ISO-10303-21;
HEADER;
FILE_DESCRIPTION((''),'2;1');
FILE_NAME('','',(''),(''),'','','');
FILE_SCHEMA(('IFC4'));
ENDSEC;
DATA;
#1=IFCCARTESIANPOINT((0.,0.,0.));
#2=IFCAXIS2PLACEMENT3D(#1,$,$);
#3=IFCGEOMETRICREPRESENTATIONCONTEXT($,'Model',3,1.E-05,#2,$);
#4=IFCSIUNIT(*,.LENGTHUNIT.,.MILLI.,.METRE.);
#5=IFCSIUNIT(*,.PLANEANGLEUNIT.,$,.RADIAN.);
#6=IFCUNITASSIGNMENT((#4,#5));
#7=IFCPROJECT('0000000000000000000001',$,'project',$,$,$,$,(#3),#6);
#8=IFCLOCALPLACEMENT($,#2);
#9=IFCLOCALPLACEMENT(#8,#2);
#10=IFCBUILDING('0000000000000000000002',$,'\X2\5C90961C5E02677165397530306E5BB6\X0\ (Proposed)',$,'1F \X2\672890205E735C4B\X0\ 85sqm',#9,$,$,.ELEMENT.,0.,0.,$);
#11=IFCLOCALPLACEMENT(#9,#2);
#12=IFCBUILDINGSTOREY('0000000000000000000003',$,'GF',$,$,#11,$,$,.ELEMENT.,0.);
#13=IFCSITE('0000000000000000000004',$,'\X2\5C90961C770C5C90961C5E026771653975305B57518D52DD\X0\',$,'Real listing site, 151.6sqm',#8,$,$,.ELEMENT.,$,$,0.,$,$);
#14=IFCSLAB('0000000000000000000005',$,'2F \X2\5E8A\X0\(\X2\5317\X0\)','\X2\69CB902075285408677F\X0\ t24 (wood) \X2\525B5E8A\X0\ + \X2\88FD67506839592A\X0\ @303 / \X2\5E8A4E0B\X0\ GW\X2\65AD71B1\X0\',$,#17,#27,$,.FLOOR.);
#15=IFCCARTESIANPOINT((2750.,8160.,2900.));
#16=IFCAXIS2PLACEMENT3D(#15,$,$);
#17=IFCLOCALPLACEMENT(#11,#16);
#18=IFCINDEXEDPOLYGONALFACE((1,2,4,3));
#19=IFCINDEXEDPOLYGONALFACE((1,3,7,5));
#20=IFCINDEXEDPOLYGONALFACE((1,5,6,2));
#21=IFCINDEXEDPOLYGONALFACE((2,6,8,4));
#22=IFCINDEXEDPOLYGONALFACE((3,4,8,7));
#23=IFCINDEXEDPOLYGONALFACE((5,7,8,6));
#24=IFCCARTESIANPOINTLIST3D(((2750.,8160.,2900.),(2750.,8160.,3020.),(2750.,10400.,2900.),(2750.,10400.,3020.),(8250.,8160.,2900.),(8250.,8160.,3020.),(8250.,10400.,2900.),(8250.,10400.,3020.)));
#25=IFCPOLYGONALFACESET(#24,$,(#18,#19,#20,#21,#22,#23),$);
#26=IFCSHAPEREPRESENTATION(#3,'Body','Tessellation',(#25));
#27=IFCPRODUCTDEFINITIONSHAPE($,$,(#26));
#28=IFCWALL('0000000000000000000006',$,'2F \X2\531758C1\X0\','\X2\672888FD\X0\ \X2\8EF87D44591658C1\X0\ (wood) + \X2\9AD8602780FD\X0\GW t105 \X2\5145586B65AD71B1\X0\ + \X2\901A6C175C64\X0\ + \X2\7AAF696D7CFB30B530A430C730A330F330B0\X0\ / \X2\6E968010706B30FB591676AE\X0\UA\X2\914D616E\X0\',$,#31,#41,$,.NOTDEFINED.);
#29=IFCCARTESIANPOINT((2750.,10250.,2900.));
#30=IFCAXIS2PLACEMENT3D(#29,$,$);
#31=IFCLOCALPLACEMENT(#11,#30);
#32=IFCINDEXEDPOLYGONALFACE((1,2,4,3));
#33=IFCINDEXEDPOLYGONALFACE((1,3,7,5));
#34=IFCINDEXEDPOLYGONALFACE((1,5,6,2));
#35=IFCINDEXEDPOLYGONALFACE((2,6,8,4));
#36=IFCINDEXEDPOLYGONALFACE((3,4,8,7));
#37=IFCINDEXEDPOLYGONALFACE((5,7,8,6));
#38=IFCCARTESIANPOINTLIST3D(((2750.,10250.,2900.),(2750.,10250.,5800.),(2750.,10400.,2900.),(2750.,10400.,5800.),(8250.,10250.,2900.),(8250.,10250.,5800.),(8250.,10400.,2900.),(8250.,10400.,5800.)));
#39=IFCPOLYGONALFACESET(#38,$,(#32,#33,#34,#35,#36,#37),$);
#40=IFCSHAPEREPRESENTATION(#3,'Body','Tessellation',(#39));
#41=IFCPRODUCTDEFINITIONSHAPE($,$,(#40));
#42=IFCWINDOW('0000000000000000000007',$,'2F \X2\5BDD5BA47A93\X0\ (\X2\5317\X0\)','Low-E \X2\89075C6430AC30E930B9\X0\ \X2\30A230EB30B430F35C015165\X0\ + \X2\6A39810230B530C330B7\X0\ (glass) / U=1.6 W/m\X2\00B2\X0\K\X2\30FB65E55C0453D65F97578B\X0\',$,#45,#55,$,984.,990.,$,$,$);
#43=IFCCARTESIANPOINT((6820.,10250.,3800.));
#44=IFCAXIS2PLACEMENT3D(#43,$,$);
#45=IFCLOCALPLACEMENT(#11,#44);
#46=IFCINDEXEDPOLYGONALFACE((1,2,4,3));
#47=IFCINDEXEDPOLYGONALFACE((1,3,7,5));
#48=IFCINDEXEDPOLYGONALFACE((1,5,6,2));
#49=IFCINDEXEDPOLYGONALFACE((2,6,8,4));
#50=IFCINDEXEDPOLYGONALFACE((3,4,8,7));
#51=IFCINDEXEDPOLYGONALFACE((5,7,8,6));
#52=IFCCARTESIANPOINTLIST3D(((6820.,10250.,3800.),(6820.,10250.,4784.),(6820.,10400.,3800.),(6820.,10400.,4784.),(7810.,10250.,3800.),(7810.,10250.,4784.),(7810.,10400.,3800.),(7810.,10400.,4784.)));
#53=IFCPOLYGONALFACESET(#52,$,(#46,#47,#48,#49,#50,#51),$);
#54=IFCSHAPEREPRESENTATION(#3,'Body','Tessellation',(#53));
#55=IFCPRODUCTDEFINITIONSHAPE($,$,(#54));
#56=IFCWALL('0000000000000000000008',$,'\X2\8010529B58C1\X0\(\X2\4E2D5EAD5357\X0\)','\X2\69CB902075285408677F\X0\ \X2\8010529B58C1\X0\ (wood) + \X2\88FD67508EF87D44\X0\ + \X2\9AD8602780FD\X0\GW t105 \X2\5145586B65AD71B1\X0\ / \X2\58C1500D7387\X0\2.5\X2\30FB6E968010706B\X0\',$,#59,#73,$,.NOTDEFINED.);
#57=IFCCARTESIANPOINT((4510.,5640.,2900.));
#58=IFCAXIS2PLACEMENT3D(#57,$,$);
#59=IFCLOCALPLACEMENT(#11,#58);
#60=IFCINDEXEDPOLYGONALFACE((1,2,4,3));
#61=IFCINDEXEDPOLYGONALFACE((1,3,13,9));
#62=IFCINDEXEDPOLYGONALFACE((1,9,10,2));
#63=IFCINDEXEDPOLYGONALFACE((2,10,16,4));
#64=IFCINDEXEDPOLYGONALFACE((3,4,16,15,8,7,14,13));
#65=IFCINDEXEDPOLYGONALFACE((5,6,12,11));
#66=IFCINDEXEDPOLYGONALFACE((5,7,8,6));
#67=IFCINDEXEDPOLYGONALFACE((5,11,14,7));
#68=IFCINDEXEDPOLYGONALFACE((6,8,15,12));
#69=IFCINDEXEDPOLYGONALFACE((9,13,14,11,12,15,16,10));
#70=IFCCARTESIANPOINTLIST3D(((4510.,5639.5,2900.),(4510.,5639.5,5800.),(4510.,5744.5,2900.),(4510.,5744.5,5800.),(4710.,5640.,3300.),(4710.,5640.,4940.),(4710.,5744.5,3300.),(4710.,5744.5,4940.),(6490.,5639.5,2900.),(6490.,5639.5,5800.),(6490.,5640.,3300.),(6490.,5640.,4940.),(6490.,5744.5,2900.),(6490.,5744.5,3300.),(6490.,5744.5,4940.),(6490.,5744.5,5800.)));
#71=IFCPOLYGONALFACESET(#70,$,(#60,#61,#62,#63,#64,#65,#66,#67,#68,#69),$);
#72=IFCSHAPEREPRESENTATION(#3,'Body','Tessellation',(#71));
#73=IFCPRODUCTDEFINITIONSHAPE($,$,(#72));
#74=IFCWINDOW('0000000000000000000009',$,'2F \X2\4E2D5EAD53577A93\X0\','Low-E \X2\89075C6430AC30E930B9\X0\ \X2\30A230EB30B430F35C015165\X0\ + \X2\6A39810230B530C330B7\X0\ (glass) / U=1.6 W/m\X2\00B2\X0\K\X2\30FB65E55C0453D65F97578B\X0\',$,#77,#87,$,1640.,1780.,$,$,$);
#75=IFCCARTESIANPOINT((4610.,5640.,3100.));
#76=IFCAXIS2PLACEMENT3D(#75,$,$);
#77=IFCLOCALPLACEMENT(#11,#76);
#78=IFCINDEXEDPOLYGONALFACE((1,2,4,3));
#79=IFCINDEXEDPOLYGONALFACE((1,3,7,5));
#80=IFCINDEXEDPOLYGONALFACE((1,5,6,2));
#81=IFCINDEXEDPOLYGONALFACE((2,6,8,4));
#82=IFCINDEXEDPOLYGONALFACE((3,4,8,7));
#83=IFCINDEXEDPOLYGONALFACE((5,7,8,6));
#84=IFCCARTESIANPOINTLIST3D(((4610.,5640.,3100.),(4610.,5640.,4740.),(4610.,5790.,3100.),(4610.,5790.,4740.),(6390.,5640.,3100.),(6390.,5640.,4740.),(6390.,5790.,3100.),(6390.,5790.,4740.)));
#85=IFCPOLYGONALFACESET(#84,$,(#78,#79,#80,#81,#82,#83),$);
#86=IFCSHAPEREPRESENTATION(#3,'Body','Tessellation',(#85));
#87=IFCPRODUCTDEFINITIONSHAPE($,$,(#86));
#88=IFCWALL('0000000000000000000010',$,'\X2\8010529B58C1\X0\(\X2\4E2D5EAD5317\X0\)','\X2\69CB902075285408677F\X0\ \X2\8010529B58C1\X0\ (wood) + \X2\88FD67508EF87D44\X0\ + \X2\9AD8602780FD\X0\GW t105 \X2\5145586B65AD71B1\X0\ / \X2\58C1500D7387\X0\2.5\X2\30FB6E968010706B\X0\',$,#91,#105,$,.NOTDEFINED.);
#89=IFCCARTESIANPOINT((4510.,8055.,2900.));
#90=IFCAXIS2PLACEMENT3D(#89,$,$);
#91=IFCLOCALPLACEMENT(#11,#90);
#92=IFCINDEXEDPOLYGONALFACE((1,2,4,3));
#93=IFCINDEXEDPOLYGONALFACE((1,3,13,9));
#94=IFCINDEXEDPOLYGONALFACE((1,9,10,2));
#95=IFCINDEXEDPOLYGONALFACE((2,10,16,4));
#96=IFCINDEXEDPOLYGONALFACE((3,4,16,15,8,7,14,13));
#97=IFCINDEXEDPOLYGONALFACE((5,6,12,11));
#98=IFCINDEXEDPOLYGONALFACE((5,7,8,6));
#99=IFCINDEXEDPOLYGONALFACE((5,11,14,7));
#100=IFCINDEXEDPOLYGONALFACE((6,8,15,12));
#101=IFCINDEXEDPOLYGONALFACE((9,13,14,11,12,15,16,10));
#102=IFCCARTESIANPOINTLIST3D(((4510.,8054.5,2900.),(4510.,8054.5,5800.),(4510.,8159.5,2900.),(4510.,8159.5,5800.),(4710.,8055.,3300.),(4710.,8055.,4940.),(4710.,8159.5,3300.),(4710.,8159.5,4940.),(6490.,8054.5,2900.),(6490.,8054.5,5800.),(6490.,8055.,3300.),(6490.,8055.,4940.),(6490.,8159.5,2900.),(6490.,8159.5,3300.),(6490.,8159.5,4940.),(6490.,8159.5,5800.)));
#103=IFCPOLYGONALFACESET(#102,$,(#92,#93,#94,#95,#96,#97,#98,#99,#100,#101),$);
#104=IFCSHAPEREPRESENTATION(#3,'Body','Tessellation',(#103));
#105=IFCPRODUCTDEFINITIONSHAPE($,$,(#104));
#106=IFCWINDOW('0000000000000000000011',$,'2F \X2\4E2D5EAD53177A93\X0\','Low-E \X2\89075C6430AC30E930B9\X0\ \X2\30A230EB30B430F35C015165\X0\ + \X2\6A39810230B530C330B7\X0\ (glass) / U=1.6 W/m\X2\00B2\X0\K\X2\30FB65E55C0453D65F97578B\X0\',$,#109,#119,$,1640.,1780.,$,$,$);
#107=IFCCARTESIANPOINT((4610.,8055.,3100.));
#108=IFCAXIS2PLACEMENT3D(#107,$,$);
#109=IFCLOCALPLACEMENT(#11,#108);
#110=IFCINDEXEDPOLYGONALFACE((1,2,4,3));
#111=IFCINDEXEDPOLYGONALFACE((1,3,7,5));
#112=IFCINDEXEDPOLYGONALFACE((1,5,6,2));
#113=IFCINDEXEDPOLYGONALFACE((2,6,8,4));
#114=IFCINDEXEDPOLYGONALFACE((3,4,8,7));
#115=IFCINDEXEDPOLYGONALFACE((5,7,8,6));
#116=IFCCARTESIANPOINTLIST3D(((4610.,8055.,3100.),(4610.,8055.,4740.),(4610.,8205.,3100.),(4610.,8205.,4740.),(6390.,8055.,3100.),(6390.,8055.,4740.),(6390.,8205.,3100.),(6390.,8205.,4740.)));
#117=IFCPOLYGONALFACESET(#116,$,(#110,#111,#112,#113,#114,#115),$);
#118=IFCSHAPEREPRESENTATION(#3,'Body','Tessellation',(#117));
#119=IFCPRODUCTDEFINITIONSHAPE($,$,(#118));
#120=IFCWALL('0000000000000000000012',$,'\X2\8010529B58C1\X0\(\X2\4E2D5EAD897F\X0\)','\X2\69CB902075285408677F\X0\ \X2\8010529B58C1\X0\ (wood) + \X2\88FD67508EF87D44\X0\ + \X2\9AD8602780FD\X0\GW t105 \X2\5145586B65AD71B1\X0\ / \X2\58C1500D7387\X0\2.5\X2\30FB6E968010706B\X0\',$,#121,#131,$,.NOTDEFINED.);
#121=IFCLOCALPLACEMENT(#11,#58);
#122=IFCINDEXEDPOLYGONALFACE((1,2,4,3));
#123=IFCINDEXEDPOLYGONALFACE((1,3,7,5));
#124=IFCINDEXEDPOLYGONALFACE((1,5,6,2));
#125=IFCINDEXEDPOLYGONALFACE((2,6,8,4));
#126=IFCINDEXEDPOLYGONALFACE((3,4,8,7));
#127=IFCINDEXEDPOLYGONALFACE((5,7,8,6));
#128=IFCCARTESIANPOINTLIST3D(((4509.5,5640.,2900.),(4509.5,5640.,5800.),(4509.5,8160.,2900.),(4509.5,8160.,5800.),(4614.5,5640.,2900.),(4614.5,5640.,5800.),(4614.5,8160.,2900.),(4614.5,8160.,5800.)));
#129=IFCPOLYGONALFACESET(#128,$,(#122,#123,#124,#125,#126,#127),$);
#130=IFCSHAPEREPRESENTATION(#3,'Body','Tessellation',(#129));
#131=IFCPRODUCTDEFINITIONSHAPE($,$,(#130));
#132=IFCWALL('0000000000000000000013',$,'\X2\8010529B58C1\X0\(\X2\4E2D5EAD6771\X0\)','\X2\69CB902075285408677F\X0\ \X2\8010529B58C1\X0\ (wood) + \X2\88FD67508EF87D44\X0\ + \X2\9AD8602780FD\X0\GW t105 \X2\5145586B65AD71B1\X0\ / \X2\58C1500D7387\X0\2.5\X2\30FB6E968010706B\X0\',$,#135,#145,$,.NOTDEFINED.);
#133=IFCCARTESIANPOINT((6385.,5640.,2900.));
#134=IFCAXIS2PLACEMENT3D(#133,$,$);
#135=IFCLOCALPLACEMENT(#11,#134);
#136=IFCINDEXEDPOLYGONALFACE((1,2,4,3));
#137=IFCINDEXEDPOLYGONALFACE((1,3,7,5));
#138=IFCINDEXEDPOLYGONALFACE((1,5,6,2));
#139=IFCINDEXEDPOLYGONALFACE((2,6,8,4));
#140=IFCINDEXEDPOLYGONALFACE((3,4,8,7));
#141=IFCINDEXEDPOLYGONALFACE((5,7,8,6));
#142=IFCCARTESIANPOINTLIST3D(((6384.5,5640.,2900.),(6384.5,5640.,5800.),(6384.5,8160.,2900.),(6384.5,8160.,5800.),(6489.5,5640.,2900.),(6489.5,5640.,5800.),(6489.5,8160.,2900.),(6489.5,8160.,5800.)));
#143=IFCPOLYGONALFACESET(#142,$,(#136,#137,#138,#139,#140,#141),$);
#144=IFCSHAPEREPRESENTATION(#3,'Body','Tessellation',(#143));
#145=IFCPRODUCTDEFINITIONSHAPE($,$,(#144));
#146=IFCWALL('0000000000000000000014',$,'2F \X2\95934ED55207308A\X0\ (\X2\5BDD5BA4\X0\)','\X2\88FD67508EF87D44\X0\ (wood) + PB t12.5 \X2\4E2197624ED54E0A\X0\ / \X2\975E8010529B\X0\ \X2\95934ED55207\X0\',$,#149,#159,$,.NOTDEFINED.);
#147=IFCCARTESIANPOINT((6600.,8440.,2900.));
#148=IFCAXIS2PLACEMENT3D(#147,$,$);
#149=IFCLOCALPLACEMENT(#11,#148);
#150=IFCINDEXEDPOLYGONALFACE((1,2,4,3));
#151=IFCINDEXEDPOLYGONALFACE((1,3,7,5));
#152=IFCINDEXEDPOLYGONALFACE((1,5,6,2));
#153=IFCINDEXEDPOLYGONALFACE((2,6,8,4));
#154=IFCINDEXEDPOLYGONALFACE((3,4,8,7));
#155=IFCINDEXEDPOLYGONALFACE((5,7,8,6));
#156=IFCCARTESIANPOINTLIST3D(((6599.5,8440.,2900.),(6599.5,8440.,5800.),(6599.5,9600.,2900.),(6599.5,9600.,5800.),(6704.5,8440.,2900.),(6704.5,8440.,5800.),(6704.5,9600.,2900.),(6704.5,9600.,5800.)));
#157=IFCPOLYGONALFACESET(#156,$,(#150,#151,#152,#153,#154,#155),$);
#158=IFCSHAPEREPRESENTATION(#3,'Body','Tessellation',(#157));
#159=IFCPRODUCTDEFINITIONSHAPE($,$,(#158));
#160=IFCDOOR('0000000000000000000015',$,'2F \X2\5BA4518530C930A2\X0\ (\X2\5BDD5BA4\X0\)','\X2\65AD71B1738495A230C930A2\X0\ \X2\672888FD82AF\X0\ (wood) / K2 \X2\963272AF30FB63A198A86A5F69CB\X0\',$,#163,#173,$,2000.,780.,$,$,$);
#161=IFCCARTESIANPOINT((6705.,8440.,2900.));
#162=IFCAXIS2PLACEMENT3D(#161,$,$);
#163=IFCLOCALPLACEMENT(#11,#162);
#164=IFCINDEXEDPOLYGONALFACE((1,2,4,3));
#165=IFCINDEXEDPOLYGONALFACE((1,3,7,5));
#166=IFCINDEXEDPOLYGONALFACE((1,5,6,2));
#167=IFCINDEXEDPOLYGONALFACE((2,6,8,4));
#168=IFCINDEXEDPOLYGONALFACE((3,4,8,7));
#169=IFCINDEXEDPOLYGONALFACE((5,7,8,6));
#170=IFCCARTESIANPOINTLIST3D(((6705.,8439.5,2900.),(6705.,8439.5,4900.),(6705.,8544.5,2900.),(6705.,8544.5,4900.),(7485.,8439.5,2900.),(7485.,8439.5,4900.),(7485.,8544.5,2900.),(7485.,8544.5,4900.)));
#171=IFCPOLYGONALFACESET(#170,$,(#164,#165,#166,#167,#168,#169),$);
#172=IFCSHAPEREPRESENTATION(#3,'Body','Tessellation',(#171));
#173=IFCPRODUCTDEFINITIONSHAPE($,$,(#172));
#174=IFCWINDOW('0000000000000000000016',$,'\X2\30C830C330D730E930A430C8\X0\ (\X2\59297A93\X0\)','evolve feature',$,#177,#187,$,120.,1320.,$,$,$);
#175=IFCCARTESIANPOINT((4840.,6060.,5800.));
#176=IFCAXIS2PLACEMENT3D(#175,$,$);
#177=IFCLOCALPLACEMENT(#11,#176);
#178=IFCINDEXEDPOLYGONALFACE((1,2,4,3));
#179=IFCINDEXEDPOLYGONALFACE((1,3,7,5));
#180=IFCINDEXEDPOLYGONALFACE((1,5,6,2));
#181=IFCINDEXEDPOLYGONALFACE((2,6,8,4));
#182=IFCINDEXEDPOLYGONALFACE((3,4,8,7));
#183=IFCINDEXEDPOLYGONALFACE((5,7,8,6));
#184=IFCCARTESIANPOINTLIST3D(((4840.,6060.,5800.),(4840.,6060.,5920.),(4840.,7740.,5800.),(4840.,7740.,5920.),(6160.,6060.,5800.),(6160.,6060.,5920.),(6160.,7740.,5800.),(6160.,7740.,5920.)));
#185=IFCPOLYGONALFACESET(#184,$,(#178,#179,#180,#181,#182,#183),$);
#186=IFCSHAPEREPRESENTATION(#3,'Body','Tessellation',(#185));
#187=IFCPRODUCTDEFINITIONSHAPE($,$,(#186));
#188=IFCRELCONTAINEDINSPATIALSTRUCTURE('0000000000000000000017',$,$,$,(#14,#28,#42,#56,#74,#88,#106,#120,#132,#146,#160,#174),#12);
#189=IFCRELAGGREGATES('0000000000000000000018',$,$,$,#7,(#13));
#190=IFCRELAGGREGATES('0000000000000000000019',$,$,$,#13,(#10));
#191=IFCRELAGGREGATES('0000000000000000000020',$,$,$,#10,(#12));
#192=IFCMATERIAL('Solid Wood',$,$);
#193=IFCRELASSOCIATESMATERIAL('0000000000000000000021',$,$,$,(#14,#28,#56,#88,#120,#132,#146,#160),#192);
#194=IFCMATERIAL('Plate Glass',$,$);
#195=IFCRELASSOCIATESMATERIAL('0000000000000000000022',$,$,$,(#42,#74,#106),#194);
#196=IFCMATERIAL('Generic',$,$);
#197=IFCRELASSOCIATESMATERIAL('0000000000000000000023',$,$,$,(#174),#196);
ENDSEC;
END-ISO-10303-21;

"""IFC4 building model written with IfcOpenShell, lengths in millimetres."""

from ifc_helpers import new_model, si_unit, frame, frame_2d, origin, place, context, project, spatial, rectangle, extrude, material, element, fill, save


model = new_model("IFC4")

# Units and contexts
model_context = context("Model", 3, precision=1e-05, world=origin())
ifc_project = project(units=[si_unit("LENGTHUNIT", "METRE", prefix="MILLI"), si_unit("PLANEANGLEUNIT", "RADIAN")], contexts=[model_context])

# Site, building, storey
site_placement = place(None, origin())
site = spatial("IfcSite", under=ifc_project, at=site_placement, Name="岐阜県岐阜市東改田字再勝", ObjectType="Real listing site, 151.6sqm", CompositionType="ELEMENT", RefElevation=0.0)
building_placement = place(site_placement, origin())
building = spatial("IfcBuilding", under=site, at=building_placement, Name="岐阜市東改田の家 (Proposed)", ObjectType="1F 木造平屋 85sqm", CompositionType="ELEMENT", ElevationOfRefHeight=0.0, ElevationOfTerrain=0.0)
storey_placement = place(building_placement, origin())
storey = spatial("IfcBuildingStorey", under=building, at=storey_placement, Name="GF", CompositionType="ELEMENT", Elevation=0.0)

# Slab
ifc_material_1 = material(Name="Solid Wood")
slab_placement = place(storey_placement, frame((2750.0, 8160.0, 2900.0)))
element("IfcSlab", 1, at=slab_placement, inside=storey, material=ifc_material_1, Name="2F 床(北)", Description="構造用合板 t24 (wood) 剛床 + 製材根太 @303 / 床下 GW断熱", PredefinedType="FLOOR", context=model_context, shape_type="SweptSolid", body=[
    extrude(rectangle(XDim=5500.0, YDim=2240.0, at=frame_2d((2750.0, 1120.0))), frame((2750.0, 8160.0, 2900.0)), (0.0, 0.0, 1.0), 120.0),
])

# Walls, openings, windows
wall_1_placement = place(storey_placement, frame((2750.0, 10250.0, 2900.0)))
wall_1 = element("IfcWall", 2, at=wall_1_placement, inside=storey, material=ifc_material_1, Name="2F 北壁", Description="木製 軸組外壁 (wood) + 高性能GW t105 充填断熱 + 通気層 + 窯業系サイディング / 準耐火・外皮UA配慮", PredefinedType="NOTDEFINED", context=model_context, shape_type="SweptSolid", body=[
    extrude(rectangle(XDim=5500.0, YDim=150.0, at=frame_2d((2750.0, 75.0))), frame((2750.0, 10250.0, 2900.0)), (0.0, 0.0, 1.0), 2900.0),
])
opening_1_placement = place(storey_placement, frame((6820.0, 10250.0, 3800.0)))
opening_1 = element("IfcOpeningElement", 3, at=opening_1_placement, cuts=wall_1, PredefinedType="NOTDEFINED", context=model_context, shape_type="SweptSolid", body=[
    extrude(rectangle(XDim=990.0, YDim=150.0, at=frame_2d((495.0, 75.0))), frame((6820.0, 10250.0, 3800.0)), (0.0, 0.0, 1.0), 984.0),
])
ifc_material_2 = material(Name="Plate Glass")
window_1_placement = place(storey_placement, frame((6820.0, 10250.0, 3800.0)))
window_1 = element("IfcWindow", 4, at=window_1_placement, inside=storey, material=ifc_material_2, Name="2F 寝室窓 (北)", Description="Low-E 複層ガラス アルゴン封入 + 樹脂サッシ (glass) / U=1.6 W/m²K・日射取得型", OverallHeight=984.0, OverallWidth=990.0, context=model_context, shape_type="SweptSolid", body=[
    extrude(rectangle(XDim=990.0, YDim=150.0, at=frame_2d((495.0, 75.0))), frame((6820.0, 10250.0, 3800.0)), (0.0, 0.0, 1.0), 984.0),
])
fill(opening_1, window_1)
wall_2_placement = place(storey_placement, frame((4510.0, 5640.0, 2900.0)))
wall_2 = element("IfcWall", 5, at=wall_2_placement, inside=storey, material=ifc_material_1, Name="耐力壁(中庭南)", Description="構造用合板 耐力壁 (wood) + 製材軸組 + 高性能GW t105 充填断熱 / 壁倍率2.5・準耐火", PredefinedType="NOTDEFINED", context=model_context, shape_type="SweptSolid", body=[
    extrude(rectangle(XDim=1980.0, YDim=105.0, at=frame_2d((990.0, 52.0))), frame((4510.0, 5640.0, 2900.0)), (0.0, 0.0, 1.0), 2900.0),
])
opening_2_placement = place(storey_placement, frame((4610.0, 5640.0, 3100.0)))
opening_2 = element("IfcOpeningElement", 6, at=opening_2_placement, cuts=wall_2, PredefinedType="NOTDEFINED", context=model_context, shape_type="SweptSolid", body=[
    extrude(rectangle(XDim=1780.0, YDim=150.0, at=frame_2d((890.0, 75.0))), frame((4610.0, 5640.0, 3100.0)), (0.0, 0.0, 1.0), 1640.0),
])
window_2_placement = place(storey_placement, frame((4610.0, 5640.0, 3100.0)))
window_2 = element("IfcWindow", 7, at=window_2_placement, inside=storey, material=ifc_material_2, Name="2F 中庭南窓", Description="Low-E 複層ガラス アルゴン封入 + 樹脂サッシ (glass) / U=1.6 W/m²K・日射取得型", OverallHeight=1640.0, OverallWidth=1780.0, context=model_context, shape_type="SweptSolid", body=[
    extrude(rectangle(XDim=1780.0, YDim=150.0, at=frame_2d((890.0, 75.0))), frame((4610.0, 5640.0, 3100.0)), (0.0, 0.0, 1.0), 1640.0),
])
fill(opening_2, window_2)
wall_3_placement = place(storey_placement, frame((4510.0, 8055.0, 2900.0)))
wall_3 = element("IfcWall", 8, at=wall_3_placement, inside=storey, material=ifc_material_1, Name="耐力壁(中庭北)", Description="構造用合板 耐力壁 (wood) + 製材軸組 + 高性能GW t105 充填断熱 / 壁倍率2.5・準耐火", PredefinedType="NOTDEFINED", context=model_context, shape_type="SweptSolid", body=[
    extrude(rectangle(XDim=1980.0, YDim=105.0, at=frame_2d((990.0, 52.0))), frame((4510.0, 8055.0, 2900.0)), (0.0, 0.0, 1.0), 2900.0),
])
opening_3_placement = place(storey_placement, frame((4610.0, 8055.0, 3100.0)))
opening_3 = element("IfcOpeningElement", 9, at=opening_3_placement, cuts=wall_3, PredefinedType="NOTDEFINED", context=model_context, shape_type="SweptSolid", body=[
    extrude(rectangle(XDim=1780.0, YDim=150.0, at=frame_2d((890.0, 75.0))), frame((4610.0, 8055.0, 3100.0)), (0.0, 0.0, 1.0), 1640.0),
])
window_3_placement = place(storey_placement, frame((4610.0, 8055.0, 3100.0)))
window_3 = element("IfcWindow", 10, at=window_3_placement, inside=storey, material=ifc_material_2, Name="2F 中庭北窓", Description="Low-E 複層ガラス アルゴン封入 + 樹脂サッシ (glass) / U=1.6 W/m²K・日射取得型", OverallHeight=1640.0, OverallWidth=1780.0, context=model_context, shape_type="SweptSolid", body=[
    extrude(rectangle(XDim=1780.0, YDim=150.0, at=frame_2d((890.0, 75.0))), frame((4610.0, 8055.0, 3100.0)), (0.0, 0.0, 1.0), 1640.0),
])
fill(opening_3, window_3)

# Walls
wall_4_placement = place(storey_placement, frame((4510.0, 5640.0, 2900.0)))
element("IfcWall", 11, at=wall_4_placement, inside=storey, material=ifc_material_1, Name="耐力壁(中庭西)", Description="構造用合板 耐力壁 (wood) + 製材軸組 + 高性能GW t105 充填断熱 / 壁倍率2.5・準耐火", PredefinedType="NOTDEFINED", context=model_context, shape_type="SweptSolid", body=[
    extrude(rectangle(XDim=105.0, YDim=2520.0, at=frame_2d((52.0, 1260.0))), frame((4510.0, 5640.0, 2900.0)), (0.0, 0.0, 1.0), 2900.0),
])
wall_5_placement = place(storey_placement, frame((6385.0, 5640.0, 2900.0)))
element("IfcWall", 12, at=wall_5_placement, inside=storey, material=ifc_material_1, Name="耐力壁(中庭東)", Description="構造用合板 耐力壁 (wood) + 製材軸組 + 高性能GW t105 充填断熱 / 壁倍率2.5・準耐火", PredefinedType="NOTDEFINED", context=model_context, shape_type="SweptSolid", body=[
    extrude(rectangle(XDim=105.0, YDim=2520.0, at=frame_2d((52.0, 1260.0))), frame((6385.0, 5640.0, 2900.0)), (0.0, 0.0, 1.0), 2900.0),
])
wall_6_placement = place(storey_placement, frame((6600.0, 8440.0, 2900.0)))
element("IfcWall", 13, at=wall_6_placement, inside=storey, material=ifc_material_1, Name="2F 間仕切り (寝室)", Description="製材軸組 (wood) + PB t12.5 両面仕上 / 非耐力 間仕切", PredefinedType="NOTDEFINED", context=model_context, shape_type="SweptSolid", body=[
    extrude(rectangle(XDim=105.0, YDim=1160.0, at=frame_2d((52.0, 580.0))), frame((6600.0, 8440.0, 2900.0)), (0.0, 0.0, 1.0), 2900.0),
])

# Door
door_placement = place(storey_placement, frame((6705.0, 8440.0, 2900.0)))
element("IfcDoor", 14, at=door_placement, inside=storey, material=ifc_material_1, Name="2F 室内ドア (寝室)", Description="断熱玄関ドア 木製芯 (wood) / K2 防犯・採風機構", OverallHeight=2000.0, OverallWidth=780.0, context=model_context, shape_type="SweptSolid", body=[
    extrude(rectangle(XDim=780.0, YDim=105.0, at=frame_2d((390.0, 52.0))), frame((6705.0, 8440.0, 2900.0)), (0.0, 0.0, 1.0), 2000.0),
])

# Window
ifc_material_3 = material(Name="Generic")
window_4_placement = place(storey_placement, frame((4840.0, 6060.0, 5800.0)))
element("IfcWindow", 15, at=window_4_placement, inside=storey, material=ifc_material_3, Name="トップライト (天窓)", Description="evolve feature", OverallHeight=120.0, OverallWidth=1320.0, context=model_context, shape_type="SweptSolid", body=[
    extrude(rectangle(XDim=1320.0, YDim=1680.0, at=frame_2d((660.0, 840.0))), frame((4840.0, 6060.0, 5800.0)), (0.0, 0.0, 1.0), 120.0),
])

save(model, "model.ifc")
